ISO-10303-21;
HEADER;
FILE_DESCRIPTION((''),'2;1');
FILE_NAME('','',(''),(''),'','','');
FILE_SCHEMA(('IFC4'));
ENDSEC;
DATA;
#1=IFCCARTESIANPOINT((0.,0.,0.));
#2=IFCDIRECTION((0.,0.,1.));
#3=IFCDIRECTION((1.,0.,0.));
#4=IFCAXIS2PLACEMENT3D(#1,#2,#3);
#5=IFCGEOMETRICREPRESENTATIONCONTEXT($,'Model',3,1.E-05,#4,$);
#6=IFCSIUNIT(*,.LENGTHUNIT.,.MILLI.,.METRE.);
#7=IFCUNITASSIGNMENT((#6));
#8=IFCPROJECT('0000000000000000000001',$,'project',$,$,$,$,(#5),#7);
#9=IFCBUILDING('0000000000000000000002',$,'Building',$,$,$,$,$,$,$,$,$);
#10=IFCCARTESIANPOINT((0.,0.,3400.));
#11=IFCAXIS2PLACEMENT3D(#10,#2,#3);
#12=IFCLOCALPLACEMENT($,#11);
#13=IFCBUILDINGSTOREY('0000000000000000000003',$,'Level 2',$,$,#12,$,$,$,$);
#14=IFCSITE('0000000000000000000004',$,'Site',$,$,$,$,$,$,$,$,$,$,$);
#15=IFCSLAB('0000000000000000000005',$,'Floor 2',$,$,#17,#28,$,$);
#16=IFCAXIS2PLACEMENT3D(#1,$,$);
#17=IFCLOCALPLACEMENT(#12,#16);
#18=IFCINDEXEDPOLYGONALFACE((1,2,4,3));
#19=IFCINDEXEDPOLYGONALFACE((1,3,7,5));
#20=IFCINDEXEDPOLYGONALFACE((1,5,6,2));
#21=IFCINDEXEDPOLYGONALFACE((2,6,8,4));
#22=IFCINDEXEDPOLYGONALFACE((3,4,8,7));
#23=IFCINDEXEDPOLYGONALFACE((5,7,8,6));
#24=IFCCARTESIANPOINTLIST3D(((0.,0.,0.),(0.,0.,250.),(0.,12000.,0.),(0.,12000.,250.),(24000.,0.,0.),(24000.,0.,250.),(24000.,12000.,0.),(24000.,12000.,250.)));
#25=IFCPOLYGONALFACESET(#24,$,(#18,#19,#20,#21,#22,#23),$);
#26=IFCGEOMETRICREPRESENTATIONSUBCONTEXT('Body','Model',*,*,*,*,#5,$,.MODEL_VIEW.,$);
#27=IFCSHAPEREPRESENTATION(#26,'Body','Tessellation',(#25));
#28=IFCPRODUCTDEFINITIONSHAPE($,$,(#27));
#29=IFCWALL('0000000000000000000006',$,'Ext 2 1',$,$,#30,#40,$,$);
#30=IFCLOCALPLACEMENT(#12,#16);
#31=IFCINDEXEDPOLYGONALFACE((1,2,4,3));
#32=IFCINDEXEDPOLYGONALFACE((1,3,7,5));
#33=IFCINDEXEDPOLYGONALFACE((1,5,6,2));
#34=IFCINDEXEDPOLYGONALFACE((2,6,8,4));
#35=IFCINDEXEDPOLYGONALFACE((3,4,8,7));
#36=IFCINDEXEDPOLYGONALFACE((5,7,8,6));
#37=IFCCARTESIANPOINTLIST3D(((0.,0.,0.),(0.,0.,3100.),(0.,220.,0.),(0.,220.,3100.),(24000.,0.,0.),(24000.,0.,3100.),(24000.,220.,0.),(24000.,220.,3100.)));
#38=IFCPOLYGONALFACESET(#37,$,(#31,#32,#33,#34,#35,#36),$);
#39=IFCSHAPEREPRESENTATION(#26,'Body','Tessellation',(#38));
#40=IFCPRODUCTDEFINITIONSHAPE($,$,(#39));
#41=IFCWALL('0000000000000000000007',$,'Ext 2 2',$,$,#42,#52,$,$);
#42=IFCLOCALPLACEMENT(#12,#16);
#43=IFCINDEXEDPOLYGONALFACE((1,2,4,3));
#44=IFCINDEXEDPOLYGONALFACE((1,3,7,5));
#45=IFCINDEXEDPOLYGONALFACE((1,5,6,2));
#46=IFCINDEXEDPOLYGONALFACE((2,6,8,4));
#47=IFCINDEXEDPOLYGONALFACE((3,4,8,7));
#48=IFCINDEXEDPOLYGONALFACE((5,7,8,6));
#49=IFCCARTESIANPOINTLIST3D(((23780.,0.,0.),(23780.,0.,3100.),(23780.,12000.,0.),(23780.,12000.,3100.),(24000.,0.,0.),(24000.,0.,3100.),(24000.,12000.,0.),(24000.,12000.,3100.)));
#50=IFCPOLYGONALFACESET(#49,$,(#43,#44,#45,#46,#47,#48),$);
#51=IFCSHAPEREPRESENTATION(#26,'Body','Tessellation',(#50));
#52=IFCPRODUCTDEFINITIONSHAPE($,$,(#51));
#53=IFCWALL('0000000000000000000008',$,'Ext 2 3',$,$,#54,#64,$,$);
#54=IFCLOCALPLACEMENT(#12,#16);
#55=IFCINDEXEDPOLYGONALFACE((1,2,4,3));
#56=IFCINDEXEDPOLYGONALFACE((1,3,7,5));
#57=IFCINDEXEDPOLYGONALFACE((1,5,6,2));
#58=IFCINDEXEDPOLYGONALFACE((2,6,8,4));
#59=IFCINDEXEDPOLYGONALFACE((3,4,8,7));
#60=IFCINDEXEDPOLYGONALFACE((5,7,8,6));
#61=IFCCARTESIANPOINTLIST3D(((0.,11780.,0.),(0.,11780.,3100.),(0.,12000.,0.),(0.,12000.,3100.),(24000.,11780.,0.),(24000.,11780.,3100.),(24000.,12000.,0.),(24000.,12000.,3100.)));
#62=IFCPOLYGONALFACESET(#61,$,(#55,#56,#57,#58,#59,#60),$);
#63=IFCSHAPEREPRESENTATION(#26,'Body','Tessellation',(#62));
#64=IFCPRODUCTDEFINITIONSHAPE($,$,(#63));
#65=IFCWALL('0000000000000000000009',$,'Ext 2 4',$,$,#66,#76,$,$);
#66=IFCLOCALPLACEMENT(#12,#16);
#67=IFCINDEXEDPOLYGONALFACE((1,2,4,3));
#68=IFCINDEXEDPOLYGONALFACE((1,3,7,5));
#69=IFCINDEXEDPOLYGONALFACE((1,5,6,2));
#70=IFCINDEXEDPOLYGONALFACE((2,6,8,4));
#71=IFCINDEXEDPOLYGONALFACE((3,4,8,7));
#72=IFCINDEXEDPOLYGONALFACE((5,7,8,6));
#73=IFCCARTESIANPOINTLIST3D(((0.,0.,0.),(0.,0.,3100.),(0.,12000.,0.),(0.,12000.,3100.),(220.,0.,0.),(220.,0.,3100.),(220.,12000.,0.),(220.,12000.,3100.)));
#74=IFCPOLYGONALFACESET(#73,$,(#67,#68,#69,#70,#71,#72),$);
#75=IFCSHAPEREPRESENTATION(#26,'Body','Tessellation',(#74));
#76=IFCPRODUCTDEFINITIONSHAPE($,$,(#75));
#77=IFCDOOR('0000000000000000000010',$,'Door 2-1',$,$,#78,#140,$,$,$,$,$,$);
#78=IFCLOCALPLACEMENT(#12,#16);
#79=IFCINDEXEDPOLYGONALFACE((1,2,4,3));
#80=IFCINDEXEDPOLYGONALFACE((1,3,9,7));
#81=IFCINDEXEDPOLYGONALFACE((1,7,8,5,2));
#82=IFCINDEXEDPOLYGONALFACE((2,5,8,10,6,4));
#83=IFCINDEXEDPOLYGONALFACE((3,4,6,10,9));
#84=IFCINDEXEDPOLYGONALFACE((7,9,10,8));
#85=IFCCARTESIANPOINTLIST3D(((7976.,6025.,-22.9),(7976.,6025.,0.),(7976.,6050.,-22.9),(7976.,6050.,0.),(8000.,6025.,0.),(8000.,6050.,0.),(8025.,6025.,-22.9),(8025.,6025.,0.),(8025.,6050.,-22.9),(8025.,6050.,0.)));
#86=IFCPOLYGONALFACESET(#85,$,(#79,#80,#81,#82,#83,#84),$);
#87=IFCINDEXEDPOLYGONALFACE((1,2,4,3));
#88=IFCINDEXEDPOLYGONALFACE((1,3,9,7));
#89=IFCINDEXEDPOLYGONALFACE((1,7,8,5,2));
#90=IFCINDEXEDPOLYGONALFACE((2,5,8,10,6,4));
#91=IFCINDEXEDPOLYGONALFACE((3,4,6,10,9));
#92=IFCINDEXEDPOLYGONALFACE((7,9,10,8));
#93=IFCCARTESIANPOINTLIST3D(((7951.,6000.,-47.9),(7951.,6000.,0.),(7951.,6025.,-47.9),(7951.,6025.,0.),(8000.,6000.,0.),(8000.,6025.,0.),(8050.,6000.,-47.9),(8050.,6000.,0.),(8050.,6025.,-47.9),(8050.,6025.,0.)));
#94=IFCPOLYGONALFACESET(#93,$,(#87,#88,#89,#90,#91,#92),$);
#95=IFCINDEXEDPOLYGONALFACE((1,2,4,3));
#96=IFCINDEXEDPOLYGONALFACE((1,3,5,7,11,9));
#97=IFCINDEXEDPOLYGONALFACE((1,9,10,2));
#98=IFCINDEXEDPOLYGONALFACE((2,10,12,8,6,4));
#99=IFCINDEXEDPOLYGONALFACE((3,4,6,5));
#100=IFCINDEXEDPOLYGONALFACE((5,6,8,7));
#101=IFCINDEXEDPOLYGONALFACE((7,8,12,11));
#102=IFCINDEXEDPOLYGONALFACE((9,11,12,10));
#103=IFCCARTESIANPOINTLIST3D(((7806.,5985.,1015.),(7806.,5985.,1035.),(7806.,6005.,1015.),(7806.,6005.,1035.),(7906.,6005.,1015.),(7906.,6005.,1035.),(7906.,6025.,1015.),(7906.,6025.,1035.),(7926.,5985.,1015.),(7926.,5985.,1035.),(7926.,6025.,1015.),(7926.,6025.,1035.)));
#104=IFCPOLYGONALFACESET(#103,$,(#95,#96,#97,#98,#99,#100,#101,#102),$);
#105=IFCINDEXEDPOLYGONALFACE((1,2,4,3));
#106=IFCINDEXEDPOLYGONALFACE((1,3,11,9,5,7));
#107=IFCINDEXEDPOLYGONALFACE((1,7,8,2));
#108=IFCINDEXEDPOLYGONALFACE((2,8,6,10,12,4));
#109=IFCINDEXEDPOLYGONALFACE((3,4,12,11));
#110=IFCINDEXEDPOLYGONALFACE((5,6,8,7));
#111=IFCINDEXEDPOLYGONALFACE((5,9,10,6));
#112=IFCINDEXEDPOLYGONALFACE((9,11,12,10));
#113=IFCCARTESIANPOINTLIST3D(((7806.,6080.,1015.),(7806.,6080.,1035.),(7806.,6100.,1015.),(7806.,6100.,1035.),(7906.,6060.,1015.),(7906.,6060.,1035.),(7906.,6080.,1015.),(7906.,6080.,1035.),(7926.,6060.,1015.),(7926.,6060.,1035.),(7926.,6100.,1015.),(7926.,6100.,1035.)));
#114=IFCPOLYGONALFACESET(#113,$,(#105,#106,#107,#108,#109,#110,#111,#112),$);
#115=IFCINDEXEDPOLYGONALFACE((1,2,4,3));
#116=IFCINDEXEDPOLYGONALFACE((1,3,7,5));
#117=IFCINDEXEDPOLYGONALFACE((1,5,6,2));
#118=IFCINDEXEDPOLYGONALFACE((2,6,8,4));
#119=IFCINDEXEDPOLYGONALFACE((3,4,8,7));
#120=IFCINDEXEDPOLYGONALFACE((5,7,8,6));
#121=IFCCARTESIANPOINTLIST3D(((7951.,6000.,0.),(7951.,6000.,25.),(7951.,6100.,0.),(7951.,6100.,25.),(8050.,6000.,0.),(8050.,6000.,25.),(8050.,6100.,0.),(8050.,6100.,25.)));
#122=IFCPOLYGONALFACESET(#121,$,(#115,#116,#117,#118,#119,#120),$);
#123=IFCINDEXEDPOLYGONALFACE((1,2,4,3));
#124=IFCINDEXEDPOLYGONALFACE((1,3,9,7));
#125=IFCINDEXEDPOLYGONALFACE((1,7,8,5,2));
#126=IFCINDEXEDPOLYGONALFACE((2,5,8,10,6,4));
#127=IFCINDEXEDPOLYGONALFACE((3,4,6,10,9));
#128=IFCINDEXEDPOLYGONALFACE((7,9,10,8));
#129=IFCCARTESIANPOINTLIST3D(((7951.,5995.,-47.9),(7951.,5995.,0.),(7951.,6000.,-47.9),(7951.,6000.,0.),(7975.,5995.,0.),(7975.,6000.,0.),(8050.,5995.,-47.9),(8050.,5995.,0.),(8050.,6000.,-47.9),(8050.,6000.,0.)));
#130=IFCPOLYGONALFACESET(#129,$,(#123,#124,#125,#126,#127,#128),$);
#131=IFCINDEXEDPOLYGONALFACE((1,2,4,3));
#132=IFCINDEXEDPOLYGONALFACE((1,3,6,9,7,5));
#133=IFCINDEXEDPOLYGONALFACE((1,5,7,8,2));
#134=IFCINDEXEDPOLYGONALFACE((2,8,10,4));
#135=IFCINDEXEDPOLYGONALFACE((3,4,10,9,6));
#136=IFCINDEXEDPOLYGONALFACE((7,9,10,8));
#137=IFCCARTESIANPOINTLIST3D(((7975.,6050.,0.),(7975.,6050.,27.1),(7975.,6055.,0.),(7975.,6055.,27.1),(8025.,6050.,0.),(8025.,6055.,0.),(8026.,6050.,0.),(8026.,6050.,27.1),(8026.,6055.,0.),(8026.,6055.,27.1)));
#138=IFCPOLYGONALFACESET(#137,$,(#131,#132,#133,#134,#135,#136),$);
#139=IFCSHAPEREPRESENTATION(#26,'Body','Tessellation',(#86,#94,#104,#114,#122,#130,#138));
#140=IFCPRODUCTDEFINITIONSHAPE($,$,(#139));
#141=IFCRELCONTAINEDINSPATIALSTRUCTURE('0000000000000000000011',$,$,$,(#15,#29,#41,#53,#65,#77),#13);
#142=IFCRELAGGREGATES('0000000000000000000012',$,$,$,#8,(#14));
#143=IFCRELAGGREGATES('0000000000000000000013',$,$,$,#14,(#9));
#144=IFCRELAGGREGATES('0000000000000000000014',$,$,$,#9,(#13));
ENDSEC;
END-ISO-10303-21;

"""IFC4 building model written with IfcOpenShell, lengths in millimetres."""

from ifc_helpers import new_model, si_unit, frame, origin_with_axes, place, context, subcontext, project, spatial, line, indexed_curve, outline, extrude, element, save


model = new_model("IFC4")

# Units and contexts
model_context = context("Model", 3, precision=1e-05, world=origin_with_axes())
body_context = subcontext(model_context, "Body", "Model", "MODEL_VIEW")
ifc_project = project(units=[si_unit("LENGTHUNIT", "METRE", prefix="MILLI")], contexts=[model_context])

# Site, building, storey
site = spatial("IfcSite", under=ifc_project, Name="Site")
building = spatial("IfcBuilding", under=site, Name="Building")
storey_placement = place(None, frame((0.0, 0.0, 3400.0), z_axis=(0.0, 0.0, 1.0), x_axis=(1.0, 0.0, 0.0)))
storey = spatial("IfcBuildingStorey", under=building, at=storey_placement, Name="Level 2")

# Slab
slab_placement = place(storey_placement, origin_with_axes())
element("IfcSlab", 1, at=slab_placement, inside=storey, Name="Floor 2", context=body_context, shape_type="SweptSolid", body=[
    extrude(outline(indexed_curve([(0.0, 0.0), (24000.0, 0.0), (24000.0, 12000.0), (0.0, 12000.0), (0.0, 0.0)])), None, (0.0, 0.0, 1.0), 250.0),
])

# Walls
wall_1_placement = place(storey_placement, origin_with_axes())
element("IfcWall", 2, at=wall_1_placement, inside=storey, Name="Ext 2 1", context=body_context, shape_type="SweptSolid", body=[
    extrude(outline(indexed_curve([(0.0, 0.0), (0.0, 220.0), (24000.0, 220.0), (24000.0, 0.0), (0.0, 0.0)], self_intersect=False)), origin_with_axes(), (0.0, 0.0, 1.0), 3100.0),
])
wall_2_placement = place(storey_placement, frame((24000.0, 0.0, 0.0), z_axis=(0.0, 0.0, 1.0), x_axis=(0.0, 1.0, 0.0)))
element("IfcWall", 3, at=wall_2_placement, inside=storey, Name="Ext 2 2", context=body_context, shape_type="SweptSolid", body=[
    extrude(outline(indexed_curve([(0.0, 0.0), (0.0, 220.0), (12000.0, 220.0), (12000.0, 0.0), (0.0, 0.0)], self_intersect=False)), origin_with_axes(), (0.0, 0.0, 1.0), 3100.0),
])
wall_3_placement = place(storey_placement, frame((24000.0, 12000.0, 0.0), z_axis=(0.0, 0.0, 1.0), x_axis=(-1.0, 0.0, 0.0)))
element("IfcWall", 4, at=wall_3_placement, inside=storey, Name="Ext 2 3", context=body_context, shape_type="SweptSolid", body=[
    extrude(outline(indexed_curve([(0.0, 0.0), (0.0, 220.0), (24000.0, 220.0), (24000.0, 0.0), (0.0, 0.0)], self_intersect=False)), origin_with_axes(), (0.0, 0.0, 1.0), 3100.0),
])
wall_4_placement = place(storey_placement, frame((0.0, 12000.0, 0.0), z_axis=(0.0, 0.0, 1.0), x_axis=(0.0, -1.0, 0.0)))
element("IfcWall", 5, at=wall_4_placement, inside=storey, Name="Ext 2 4", context=body_context, shape_type="SweptSolid", body=[
    extrude(outline(indexed_curve([(0.0, 0.0), (0.0, 220.0), (12000.0, 220.0), (12000.0, 0.0), (0.0, 0.0)], self_intersect=False)), origin_with_axes(), (0.0, 0.0, 1.0), 3100.0),
])

# Door
door_1_placement = place(storey_placement, frame((8000.0, 6000.0, 0.0), z_axis=(0.0, 0.0, 1.0), x_axis=(1.0, 0.0, 0.0)))
element("IfcDoor", 6, at=door_1_placement, inside=storey, Name="Door 2-1", context=body_context, shape_type="SweptSolid", body=[
    extrude(outline(indexed_curve([(0.0, 0.0), (0.0, 2.1), (1.0, 2.1), (1.0, 0.0), (-24.0, 0.0), (-24.0, -22.9), (25.0, -22.9), (25.0, 0.0)], segments=[line(1, 2, 3, 4, 5, 6, 7, 8, 1)])), frame((0.0, 25.0, 0.0), z_axis=(0.0, -1.0, 0.0), x_axis=(1.0, 0.0, 0.0)), (0.0, 0.0, -1.0), 25.0),
    extrude(outline(indexed_curve([(0.0, 0.0), (0.0, 2.1), (1.0, 2.1), (1.0, 0.0), (-49.0, 0.0), (-49.0, -47.9), (50.0, -47.9), (50.0, 0.0)], segments=[line(1, 2, 3, 4, 5, 6, 7, 8, 1)])), frame((0.0, 0.0, 0.0), z_axis=(0.0, -1.0, 0.0), x_axis=(1.0, 0.0, 0.0)), (0.0, 0.0, -1.0), 25.0),
    extrude(outline(indexed_curve([(0.0, 0.0), (-49.0, 0.0), (-49.0, 35.0), (0.0, 35.0)], segments=[line(1, 2, 3, 4, 1)])), frame((25.0, 25.0, 25.0), z_axis=(0.0, 0.0, 1.0), x_axis=(1.0, 0.0, 0.0)), (0.0, 0.0, 1.0), -47.9),
    extrude(outline(indexed_curve([(0.0, 0.0), (0.0, -40.0), (-120.0, -40.0), (-120.0, -20.0), (-20.0, -20.0), (-20.0, 0.0)], segments=[line(1, 2, 3, 4, 5, 6, 1)])), frame((-74.0, 25.0, 1015.0), z_axis=(0.0, 0.0, 1.0), x_axis=(1.0, 0.0, 0.0)), (0.0, 0.0, 1.0), 20.0),
    extrude(outline(indexed_curve([(0.0, 0.0), (0.0, 40.0), (-120.0, 40.0), (-120.0, 20.0), (-20.0, 20.0), (-20.0, 0.0)], segments=[line(1, 2, 3, 4, 5, 6, 1)])), frame((-74.0, 60.0, 1015.0), z_axis=(0.0, 0.0, 1.0), x_axis=(1.0, 0.0, 0.0)), (0.0, 0.0, 1.0), 20.0),
    extrude(outline(indexed_curve([(0.0, 0.0), (-99.0, 0.0), (-99.0, 100.0), (0.0, 100.0)], segments=[line(1, 2, 3, 4, 1)])), frame((50.0, 0.0, 0.0), z_axis=(0.0, 0.0, 1.0), x_axis=(1.0, 0.0, 0.0)), (0.0, 0.0, 1.0), 25.0),
    extrude(outline(indexed_curve([(0.0, 0.0), (0.0, 27.1), (51.0, 27.1), (51.0, 0.0), (-24.0, 0.0), (-24.0, -47.9), (75.0, -47.9), (75.0, 0.0)], segments=[line(1, 2, 3, 4, 5, 6, 7, 8, 1)])), frame((-25.0, -5.0, 0.0), z_axis=(0.0, -1.0, 0.0), x_axis=(1.0, 0.0, 0.0)), (0.0, 0.0, -1.0), 5.0),
    extrude(outline(indexed_curve([(0.0, 0.0), (0.0, 27.1), (51.0, 27.1), (51.0, 0.0), (1.0, 0.0), (1.0, -22.9), (50.0, -22.9), (50.0, 0.0)], segments=[line(1, 2, 3, 4, 5, 6, 7, 8, 1)])), frame((-25.0, 50.0, 0.0), z_axis=(0.0, -1.0, 0.0), x_axis=(1.0, 0.0, 0.0)), (0.0, 0.0, -1.0), 5.0),
])

save(model, "model.ifc")
